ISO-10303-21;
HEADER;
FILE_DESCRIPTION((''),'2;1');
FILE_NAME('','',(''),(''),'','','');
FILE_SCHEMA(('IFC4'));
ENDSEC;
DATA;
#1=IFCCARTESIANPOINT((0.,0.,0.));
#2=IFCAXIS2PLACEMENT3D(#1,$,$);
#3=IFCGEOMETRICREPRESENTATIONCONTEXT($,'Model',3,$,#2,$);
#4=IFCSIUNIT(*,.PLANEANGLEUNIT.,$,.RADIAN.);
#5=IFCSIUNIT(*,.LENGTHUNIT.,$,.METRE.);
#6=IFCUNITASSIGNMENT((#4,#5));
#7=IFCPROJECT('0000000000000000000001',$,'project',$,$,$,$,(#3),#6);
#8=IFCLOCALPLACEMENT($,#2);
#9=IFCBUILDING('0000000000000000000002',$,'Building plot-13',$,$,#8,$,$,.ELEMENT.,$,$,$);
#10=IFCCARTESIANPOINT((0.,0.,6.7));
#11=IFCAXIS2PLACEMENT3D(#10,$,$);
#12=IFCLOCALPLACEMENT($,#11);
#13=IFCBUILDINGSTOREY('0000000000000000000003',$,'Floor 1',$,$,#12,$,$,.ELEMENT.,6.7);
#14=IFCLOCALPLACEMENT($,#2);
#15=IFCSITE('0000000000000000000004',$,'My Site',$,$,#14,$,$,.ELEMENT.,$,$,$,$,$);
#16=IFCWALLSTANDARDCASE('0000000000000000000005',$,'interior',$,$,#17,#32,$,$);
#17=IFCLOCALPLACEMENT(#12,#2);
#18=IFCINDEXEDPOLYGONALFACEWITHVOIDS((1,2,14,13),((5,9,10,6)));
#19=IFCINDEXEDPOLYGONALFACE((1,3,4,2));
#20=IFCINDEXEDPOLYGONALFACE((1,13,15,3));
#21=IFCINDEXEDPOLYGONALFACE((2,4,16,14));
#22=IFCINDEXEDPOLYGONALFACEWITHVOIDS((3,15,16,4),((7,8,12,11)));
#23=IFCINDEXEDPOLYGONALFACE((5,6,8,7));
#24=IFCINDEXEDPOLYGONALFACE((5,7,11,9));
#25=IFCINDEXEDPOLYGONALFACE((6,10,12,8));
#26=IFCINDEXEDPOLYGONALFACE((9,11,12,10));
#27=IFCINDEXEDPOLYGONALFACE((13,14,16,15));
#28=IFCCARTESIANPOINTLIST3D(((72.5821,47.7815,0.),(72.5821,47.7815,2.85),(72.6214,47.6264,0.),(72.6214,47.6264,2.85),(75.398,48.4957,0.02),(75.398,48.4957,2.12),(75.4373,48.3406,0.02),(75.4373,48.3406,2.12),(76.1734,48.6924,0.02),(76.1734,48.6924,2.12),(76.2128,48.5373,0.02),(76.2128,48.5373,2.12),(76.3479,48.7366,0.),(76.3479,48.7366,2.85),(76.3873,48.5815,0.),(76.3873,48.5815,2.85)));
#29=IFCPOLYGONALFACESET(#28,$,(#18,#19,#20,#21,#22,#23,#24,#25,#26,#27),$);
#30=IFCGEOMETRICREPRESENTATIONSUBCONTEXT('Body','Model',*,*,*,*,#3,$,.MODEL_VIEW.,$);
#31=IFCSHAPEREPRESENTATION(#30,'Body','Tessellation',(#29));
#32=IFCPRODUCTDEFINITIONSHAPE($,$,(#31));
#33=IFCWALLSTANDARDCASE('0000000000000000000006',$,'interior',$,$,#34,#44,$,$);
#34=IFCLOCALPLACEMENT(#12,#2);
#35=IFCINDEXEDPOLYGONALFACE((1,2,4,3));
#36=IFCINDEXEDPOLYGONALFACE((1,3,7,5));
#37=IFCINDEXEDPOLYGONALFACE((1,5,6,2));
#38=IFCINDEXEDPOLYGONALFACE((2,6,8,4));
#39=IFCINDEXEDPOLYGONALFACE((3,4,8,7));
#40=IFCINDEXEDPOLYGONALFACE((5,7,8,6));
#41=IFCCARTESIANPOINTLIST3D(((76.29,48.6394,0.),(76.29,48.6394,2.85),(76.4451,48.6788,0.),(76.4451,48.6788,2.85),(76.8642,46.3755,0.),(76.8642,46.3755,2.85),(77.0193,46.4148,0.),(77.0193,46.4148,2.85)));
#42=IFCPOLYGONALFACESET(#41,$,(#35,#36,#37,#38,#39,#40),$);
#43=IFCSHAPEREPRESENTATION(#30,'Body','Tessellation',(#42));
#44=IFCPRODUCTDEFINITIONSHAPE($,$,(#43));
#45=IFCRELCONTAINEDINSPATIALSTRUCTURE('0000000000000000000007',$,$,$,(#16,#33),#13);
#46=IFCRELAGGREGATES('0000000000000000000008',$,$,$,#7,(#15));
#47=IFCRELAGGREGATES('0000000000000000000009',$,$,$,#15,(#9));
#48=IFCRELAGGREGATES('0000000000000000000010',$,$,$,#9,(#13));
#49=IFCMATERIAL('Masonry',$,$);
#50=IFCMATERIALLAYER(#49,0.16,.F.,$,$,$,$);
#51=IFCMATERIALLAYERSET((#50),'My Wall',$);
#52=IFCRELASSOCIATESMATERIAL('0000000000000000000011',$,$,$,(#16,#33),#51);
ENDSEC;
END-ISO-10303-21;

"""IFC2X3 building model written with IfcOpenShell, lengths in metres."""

from ifc_helpers import new_model, si_unit, frame, origin, place, context, subcontext, project, spatial, polyline, outline, extrude, material, layer, layer_set, layer_usage, element, save


model = new_model("IFC2X3")

# Units and contexts
model_context = context("Model", 3, world=origin())
body_context = subcontext(model_context, "Body", "Model", "MODEL_VIEW")
ifc_project = project(units=[si_unit("PLANEANGLEUNIT", "RADIAN"), si_unit("LENGTHUNIT", "METRE")], contexts=[model_context])

# Site, building, storey
site_placement = place(None, origin())
site = spatial("IfcSite", under=ifc_project, at=site_placement, Name="My Site", CompositionType="ELEMENT")
building_placement = place(None, origin())
building = spatial("IfcBuilding", under=site, at=building_placement, Name="Building plot-13", CompositionType="ELEMENT")
storey_placement = place(None, frame((0.0, 0.0, 6.7)))
storey = spatial("IfcBuildingStorey", under=building, at=storey_placement, Name="Floor 1", CompositionType="ELEMENT", Elevation=6.7)

# Shared definitions
ifc_material = material(Name="Masonry")
ifc_layer = layer(ifc_material, 0.16, ventilated=False)
ifc_layer_set = layer_set([ifc_layer], Name="My Wall")
ifc_layer_usage = layer_usage(ifc_layer_set, "AXIS2", "NEGATIVE", 0.08)

# Wall, opening
wall_1_placement = place(storey_placement, origin())
wall_1 = element("IfcWallStandardCase", 1, at=wall_1_placement, inside=storey, material=ifc_layer_usage, Name="interior", context=body_context, shape_type="SweptSolid", body=[
    extrude(outline(polyline([(76.3873, 48.5815), (76.3479, 48.7366), (72.5821, 47.7815), (72.6214, 47.6264), (76.3873, 48.5815)])), origin(), (0.0, 0.0, 1.0), 2.85),
])
opening_1_placement = place(storey_placement, frame((0.0, 0.0, 0.02)))
element("IfcOpeningElement", 2, at=opening_1_placement, cuts=wall_1, ObjectType="Opening", context=body_context, shape_type="SweptSolid", body=[
    extrude(outline(polyline([(76.1734, 48.6924), (75.398, 48.4957), (75.4373, 48.3406), (76.2128, 48.5373), (76.1734, 48.6924)])), origin(), (0.0, 0.0, 1.0), 2.1),
])

# Wall
wall_2_placement = place(storey_placement, origin())
element("IfcWallStandardCase", 3, at=wall_2_placement, inside=storey, material=ifc_layer_usage, Name="interior", context=body_context, shape_type="SweptSolid", body=[
    extrude(outline(polyline([(76.4451, 48.6788), (76.29, 48.6394), (76.8642, 46.3755), (77.0193, 46.4148), (76.4451, 48.6788)])), origin(), (0.0, 0.0, 1.0), 2.85),
])

save(model, "model.ifc")
